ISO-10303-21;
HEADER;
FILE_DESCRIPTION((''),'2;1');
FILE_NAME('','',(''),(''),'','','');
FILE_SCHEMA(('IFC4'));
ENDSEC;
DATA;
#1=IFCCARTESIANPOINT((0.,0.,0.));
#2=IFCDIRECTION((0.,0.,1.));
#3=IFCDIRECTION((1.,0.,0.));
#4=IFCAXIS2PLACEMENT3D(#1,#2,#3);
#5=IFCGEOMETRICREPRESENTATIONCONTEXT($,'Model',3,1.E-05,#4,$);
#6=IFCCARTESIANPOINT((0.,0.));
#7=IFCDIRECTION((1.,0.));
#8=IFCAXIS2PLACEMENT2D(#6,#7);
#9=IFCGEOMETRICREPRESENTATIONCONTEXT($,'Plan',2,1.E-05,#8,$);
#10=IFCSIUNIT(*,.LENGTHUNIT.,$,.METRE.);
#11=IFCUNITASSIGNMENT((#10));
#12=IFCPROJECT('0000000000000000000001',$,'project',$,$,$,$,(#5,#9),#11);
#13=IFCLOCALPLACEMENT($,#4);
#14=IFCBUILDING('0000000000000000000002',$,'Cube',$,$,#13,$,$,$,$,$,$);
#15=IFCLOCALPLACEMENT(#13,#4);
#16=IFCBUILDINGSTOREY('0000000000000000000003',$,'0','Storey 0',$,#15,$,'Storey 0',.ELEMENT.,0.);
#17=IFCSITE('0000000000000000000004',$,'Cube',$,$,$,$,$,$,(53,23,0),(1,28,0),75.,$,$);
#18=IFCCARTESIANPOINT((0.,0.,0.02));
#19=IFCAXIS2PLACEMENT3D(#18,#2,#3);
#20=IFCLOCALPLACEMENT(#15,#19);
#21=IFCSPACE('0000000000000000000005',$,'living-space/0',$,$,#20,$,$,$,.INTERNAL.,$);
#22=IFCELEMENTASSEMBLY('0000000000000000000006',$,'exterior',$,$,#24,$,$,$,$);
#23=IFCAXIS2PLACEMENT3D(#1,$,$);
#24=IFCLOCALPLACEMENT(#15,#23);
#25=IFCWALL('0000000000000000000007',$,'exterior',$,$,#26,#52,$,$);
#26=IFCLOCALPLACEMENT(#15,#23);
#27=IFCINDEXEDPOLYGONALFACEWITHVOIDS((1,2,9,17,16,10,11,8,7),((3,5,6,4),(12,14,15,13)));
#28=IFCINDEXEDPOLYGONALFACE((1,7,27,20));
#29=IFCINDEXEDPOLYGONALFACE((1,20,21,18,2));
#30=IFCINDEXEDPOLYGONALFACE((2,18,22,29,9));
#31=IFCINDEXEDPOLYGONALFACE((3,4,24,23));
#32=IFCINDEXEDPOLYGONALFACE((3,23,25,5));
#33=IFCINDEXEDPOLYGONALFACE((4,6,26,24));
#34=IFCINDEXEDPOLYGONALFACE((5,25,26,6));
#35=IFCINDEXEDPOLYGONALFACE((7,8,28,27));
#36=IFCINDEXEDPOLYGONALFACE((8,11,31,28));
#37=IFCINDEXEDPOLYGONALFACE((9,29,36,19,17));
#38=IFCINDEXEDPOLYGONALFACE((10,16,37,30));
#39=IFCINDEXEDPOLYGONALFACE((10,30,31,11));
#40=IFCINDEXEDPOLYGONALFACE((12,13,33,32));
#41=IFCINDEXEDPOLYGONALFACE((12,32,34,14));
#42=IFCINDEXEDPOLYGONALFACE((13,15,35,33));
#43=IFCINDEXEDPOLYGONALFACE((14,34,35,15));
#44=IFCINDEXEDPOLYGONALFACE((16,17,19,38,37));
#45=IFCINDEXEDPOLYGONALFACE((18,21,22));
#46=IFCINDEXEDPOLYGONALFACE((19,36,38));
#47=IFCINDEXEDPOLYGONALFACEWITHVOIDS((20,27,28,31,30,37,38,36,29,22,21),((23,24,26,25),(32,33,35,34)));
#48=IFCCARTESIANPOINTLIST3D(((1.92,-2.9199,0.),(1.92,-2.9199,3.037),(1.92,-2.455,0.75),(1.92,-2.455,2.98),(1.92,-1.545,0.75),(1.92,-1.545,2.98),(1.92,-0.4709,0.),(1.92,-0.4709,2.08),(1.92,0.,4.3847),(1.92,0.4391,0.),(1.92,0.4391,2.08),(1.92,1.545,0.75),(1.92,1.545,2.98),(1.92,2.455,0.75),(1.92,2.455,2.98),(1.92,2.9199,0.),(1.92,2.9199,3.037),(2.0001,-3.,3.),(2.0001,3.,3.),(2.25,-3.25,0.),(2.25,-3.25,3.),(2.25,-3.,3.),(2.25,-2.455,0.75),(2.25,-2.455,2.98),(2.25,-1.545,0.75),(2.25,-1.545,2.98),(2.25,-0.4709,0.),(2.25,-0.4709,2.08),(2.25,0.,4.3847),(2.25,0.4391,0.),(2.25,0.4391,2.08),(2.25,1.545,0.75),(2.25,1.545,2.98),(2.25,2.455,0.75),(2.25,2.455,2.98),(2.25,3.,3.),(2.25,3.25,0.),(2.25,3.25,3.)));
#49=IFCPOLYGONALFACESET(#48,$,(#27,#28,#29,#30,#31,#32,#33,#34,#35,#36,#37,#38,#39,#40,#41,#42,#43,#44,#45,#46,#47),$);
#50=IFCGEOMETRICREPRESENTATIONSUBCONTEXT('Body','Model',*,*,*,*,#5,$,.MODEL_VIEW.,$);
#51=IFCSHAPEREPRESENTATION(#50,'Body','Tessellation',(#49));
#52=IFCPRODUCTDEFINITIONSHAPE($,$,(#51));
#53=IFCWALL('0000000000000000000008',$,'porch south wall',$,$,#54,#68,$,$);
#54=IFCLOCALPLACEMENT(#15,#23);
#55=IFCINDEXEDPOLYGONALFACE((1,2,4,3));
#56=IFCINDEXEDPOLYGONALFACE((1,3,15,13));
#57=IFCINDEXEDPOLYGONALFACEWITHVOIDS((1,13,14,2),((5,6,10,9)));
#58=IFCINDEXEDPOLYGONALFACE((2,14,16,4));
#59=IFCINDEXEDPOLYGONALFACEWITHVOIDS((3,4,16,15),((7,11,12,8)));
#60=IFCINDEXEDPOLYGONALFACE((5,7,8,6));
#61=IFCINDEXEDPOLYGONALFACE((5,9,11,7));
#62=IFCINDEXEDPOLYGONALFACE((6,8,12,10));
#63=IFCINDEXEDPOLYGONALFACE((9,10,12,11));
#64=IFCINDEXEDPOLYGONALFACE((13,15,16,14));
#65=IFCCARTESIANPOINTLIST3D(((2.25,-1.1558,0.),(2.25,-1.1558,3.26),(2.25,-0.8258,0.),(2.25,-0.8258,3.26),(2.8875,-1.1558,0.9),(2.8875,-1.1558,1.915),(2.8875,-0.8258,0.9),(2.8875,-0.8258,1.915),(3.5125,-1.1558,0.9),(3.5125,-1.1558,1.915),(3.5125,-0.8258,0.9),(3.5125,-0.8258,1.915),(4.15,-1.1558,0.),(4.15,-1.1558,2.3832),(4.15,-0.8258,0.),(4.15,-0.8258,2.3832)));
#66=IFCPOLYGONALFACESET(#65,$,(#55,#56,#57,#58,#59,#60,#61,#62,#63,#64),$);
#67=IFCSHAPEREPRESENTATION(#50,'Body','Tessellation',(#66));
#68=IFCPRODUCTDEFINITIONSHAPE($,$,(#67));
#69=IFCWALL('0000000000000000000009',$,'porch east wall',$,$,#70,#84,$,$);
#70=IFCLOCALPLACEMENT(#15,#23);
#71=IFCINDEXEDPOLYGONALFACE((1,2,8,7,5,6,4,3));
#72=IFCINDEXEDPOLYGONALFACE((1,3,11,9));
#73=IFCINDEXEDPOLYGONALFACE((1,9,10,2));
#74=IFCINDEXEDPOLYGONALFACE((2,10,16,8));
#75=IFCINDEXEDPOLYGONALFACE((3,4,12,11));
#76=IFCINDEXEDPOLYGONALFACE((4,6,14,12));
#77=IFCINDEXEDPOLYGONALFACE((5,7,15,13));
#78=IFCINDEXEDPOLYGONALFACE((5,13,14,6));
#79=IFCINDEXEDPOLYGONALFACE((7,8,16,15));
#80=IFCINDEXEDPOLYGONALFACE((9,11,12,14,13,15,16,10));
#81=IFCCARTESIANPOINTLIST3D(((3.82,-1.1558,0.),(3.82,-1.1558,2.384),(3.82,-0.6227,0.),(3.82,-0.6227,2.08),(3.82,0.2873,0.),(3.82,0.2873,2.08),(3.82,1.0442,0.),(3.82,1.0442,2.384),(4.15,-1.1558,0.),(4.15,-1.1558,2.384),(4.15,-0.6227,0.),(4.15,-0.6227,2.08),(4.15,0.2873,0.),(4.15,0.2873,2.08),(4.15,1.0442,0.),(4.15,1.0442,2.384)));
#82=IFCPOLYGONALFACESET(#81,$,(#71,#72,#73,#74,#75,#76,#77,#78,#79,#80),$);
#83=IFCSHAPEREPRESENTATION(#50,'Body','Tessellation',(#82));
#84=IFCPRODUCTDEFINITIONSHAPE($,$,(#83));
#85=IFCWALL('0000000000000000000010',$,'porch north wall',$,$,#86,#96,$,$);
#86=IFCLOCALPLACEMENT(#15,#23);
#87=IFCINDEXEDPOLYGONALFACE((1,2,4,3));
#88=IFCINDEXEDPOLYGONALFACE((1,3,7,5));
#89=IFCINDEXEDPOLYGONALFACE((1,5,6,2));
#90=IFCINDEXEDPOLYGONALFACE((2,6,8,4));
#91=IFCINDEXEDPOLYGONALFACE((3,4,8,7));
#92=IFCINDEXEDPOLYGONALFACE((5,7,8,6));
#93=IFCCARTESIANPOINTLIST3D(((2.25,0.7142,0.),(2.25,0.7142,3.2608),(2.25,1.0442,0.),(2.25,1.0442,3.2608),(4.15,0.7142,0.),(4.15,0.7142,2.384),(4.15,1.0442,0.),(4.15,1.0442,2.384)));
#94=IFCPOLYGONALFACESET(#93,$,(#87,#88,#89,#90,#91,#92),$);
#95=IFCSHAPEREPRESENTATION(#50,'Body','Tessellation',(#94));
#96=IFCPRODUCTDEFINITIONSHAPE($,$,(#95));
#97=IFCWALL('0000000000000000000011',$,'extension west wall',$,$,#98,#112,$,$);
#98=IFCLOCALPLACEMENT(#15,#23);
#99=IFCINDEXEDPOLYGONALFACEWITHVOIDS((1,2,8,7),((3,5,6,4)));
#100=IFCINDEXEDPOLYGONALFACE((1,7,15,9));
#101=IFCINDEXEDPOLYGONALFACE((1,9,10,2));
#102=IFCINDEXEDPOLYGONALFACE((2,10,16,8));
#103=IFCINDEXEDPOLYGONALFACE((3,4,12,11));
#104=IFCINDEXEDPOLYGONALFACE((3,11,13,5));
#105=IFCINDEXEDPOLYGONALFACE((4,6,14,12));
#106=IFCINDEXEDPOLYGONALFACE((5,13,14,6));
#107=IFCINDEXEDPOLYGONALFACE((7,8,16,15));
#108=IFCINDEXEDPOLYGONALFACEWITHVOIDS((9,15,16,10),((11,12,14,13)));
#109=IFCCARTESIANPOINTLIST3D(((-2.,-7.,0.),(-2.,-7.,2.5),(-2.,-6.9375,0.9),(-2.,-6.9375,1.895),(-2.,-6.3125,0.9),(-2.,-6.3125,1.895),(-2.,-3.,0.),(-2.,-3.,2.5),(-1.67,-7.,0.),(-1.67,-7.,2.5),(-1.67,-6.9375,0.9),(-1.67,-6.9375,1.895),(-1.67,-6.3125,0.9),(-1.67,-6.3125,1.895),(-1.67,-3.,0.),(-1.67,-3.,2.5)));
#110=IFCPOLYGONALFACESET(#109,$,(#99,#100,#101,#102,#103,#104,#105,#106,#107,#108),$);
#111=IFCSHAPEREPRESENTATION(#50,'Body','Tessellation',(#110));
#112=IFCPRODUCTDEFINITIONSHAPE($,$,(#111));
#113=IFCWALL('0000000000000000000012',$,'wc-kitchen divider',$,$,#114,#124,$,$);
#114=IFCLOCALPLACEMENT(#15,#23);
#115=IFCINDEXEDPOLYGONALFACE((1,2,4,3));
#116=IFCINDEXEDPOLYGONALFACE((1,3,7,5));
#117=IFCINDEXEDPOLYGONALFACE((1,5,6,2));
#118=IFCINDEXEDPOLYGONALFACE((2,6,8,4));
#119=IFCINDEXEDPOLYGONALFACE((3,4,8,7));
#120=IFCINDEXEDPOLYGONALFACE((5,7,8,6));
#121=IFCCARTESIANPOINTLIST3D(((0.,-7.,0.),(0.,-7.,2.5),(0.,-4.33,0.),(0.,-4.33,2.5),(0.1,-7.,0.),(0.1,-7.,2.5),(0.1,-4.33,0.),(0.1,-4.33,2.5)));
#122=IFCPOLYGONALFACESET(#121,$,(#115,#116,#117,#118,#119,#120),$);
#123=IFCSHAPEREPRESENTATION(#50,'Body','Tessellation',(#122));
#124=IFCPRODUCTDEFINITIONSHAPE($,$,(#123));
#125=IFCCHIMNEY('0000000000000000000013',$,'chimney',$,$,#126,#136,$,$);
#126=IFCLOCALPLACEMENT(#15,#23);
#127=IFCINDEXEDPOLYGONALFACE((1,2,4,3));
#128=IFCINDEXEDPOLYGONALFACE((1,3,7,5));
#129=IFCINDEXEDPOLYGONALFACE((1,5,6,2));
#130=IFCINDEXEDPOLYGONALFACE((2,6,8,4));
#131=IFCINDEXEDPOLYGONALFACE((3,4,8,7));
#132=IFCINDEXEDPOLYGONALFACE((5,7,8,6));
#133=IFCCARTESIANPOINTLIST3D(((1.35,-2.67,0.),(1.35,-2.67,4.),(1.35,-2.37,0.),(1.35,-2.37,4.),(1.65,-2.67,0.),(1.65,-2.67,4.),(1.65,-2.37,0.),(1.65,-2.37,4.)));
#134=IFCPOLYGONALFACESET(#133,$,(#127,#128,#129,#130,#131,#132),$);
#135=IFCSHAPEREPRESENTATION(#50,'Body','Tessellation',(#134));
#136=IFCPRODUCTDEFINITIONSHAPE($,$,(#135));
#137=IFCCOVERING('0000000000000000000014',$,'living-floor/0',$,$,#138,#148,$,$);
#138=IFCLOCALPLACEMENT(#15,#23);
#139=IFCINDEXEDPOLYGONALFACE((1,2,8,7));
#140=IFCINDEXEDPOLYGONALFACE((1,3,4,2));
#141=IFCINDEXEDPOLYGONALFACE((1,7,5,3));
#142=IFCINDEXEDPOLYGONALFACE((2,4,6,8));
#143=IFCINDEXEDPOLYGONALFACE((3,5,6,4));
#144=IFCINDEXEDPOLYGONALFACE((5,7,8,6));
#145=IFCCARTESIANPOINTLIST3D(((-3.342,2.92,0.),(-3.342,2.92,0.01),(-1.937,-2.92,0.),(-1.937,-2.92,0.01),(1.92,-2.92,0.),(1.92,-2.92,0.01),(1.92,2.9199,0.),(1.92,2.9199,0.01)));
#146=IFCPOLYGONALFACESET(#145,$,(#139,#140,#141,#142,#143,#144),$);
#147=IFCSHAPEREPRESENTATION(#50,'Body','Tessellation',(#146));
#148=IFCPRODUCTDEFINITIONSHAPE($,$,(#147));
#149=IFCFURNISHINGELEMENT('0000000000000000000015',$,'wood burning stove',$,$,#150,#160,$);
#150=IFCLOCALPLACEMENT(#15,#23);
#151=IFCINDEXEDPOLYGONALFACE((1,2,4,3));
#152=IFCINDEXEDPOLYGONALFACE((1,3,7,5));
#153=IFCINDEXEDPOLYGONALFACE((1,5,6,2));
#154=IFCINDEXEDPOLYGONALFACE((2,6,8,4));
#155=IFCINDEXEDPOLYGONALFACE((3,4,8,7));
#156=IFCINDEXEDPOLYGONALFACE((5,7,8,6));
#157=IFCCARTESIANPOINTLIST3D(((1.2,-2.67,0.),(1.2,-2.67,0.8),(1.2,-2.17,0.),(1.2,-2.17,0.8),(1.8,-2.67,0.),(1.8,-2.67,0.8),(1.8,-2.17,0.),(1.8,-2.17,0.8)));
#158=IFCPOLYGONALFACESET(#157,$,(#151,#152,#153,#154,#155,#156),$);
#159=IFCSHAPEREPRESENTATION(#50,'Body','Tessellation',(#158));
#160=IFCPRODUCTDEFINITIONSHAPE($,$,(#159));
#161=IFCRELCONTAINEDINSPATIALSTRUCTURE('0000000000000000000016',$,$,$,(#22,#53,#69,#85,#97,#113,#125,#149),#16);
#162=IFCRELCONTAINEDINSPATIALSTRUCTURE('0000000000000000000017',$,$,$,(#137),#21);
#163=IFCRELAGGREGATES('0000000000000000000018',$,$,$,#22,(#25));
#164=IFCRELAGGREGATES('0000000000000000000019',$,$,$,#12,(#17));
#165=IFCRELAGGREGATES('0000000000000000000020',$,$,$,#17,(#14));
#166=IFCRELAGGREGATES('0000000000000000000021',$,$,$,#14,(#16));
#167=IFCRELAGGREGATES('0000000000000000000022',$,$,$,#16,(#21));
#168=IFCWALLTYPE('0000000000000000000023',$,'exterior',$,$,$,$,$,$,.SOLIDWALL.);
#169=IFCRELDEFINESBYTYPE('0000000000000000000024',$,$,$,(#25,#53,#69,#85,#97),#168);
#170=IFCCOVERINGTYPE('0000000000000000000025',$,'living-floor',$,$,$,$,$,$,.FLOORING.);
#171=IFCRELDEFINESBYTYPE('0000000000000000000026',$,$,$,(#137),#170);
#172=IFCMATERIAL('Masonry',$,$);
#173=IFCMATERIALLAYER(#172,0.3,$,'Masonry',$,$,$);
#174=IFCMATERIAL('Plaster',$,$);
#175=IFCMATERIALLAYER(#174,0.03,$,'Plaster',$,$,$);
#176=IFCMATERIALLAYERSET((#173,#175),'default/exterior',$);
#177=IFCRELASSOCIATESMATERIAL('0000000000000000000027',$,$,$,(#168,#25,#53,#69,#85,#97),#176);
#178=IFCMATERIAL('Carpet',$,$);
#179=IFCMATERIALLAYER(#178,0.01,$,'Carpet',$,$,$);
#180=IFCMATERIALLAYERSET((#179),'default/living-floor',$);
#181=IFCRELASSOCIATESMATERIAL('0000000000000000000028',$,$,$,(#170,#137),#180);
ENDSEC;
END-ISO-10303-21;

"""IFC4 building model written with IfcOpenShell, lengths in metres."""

from ifc_helpers import new_model, si_unit, frame, origin, origin_with_axes, origin_2d_with_axis, place, context, subcontext, project, spatial, polyline, line, indexed_curve, outline, extrude, clip, halfspace, bounded_halfspace, source, transform, mapped, material, layer, layer_set, layer_usage, type_object, element, aggregate, save


model = new_model("IFC4")

# Units and contexts
model_context = context("Model", 3, precision=1e-05, world=origin_with_axes())
plan_context = context("Plan", 2, precision=1e-05, world=origin_2d_with_axis())
body_context = subcontext(model_context, "Body", "Model", "MODEL_VIEW")
ifc_project = project(units=[si_unit("LENGTHUNIT", "METRE")], contexts=[model_context, plan_context])

# Site, building, storey
site = spatial("IfcSite", under=ifc_project, Name="Cube", RefLatitude=(53, 23, 0), RefLongitude=(1, 28, 0), RefElevation=75.0)
building_placement = place(None, origin_with_axes())
building = spatial("IfcBuilding", under=site, at=building_placement, Name="Cube")
storey_placement = place(building_placement, origin_with_axes())
storey = spatial("IfcBuildingStorey", under=building, at=storey_placement, Name="0", Description="Storey 0", LongName="Storey 0", CompositionType="ELEMENT", Elevation=0.0)

# Element assembly, wall, openings
ifc_material_1 = material(Name="Masonry")
ifc_layer_1 = layer(ifc_material_1, 0.3, Name="Masonry")
ifc_material_2 = material(Name="Plaster")
ifc_layer_2 = layer(ifc_material_2, 0.03, Name="Plaster")
ifc_layer_set_1 = layer_set([ifc_layer_1, ifc_layer_2], Name="default/exterior")
wall_type = type_object("IfcWallType", Name="exterior", PredefinedType="SOLIDWALL", material=ifc_layer_set_1)
assembly_1_placement = place(storey_placement, frame((2.0, -3.0, 0.0), z_axis=(0.0, 0.0, 1.0), x_axis=(0.0, 1.0, 0.0)))
assembly_1 = element("IfcElementAssembly", 1, at=assembly_1_placement, inside=storey, Name="exterior")
ifc_layer_usage_1 = layer_usage(ifc_layer_set_1, "AXIS2", "POSITIVE", -0.25)
wall_1_placement = place(assembly_1_placement, origin_with_axes())
wall_1 = element("IfcWall", 2, at=wall_1_placement, type_object=wall_type, material=ifc_layer_usage_1, Name="exterior", context=body_context, shape_type="Clipping", body=[
    clip(clip(clip(clip(extrude(outline(polyline([(0.0801, 0.08), (-0.25, -0.25), (6.25, -0.25), (5.9199, 0.08), (0.0801, 0.08)])), origin(), (0.0, 0.0, 1.0), 4.385), bounded_halfspace(frame((6.0, 0.0, 3.0), z_axis=(0.419069, 0.0, 0.907954), x_axis=(0.0, -1.0, 0.0)), False, origin(), polyline([(6.0, -1.0), (3.0, -1.0), (3.0, 1.0), (6.0, 1.0), (6.0, -1.0)]))), bounded_halfspace(frame((6.0, 0.0, 3.0), z_axis=(0.0, 0.0, 1.0), x_axis=(0.0, 1.0, 0.0)), False, origin(), polyline([(6.0, 1.0), (7.0, 1.0), (7.0, -1.0), (6.0, -1.0), (6.0, 1.0)]))), bounded_halfspace(frame((3.0, 0.0, 4.3847), z_axis=(-0.419069, 0.0, 0.907954), x_axis=(0.0, -1.0, 0.0)), False, origin(), polyline([(3.0, -1.0), (0.0, -1.0), (0.0, 1.0), (3.0, 1.0), (3.0, -1.0)]))), bounded_halfspace(frame((0.0, 0.0, 3.0), z_axis=(0.0, 0.0, 1.0), x_axis=(0.0, -1.0, 0.0)), False, origin(), polyline([(0.0, -1.0), (-1.0, -1.0), (-1.0, 1.0), (0.0, 1.0), (0.0, -1.0)]))),
])
opening_1_placement = place(wall_1_placement, frame((0.545, -0.25, 0.75), z_axis=(0.0, 0.0, 1.0), x_axis=(1.0, 0.0, 0.0)))
element("IfcOpeningElement", 3, at=opening_1_placement, cuts=wall_1, PredefinedType="OPENING", context=body_context, shape_type="SweptSolid", body=[
    extrude(outline(polyline([(0.0, -0.02), (0.91, -0.02), (0.91, 0.35), (0.0, 0.35), (0.0, -0.02)])), origin(), (0.0, 0.0, 1.0), 2.23),
])
opening_2_placement = place(wall_1_placement, frame((4.545, -0.25, 0.75), z_axis=(0.0, 0.0, 1.0), x_axis=(1.0, 0.0, 0.0)))
element("IfcOpeningElement", 4, at=opening_2_placement, cuts=wall_1, PredefinedType="OPENING", context=body_context, shape_type="SweptSolid", body=[
    extrude(outline(polyline([(0.0, -0.02), (0.91, -0.02), (0.91, 0.35), (0.0, 0.35), (0.0, -0.02)])), origin(), (0.0, 0.0, 1.0), 2.23),
])
shared_shape_1 = source(origin_with_axes(), body_context, "Body", "SweptSolid", [
    extrude(outline(indexed_curve([(0.0, 0.0), (0.91, 0.0), (0.91, 2.08), (0.0, 2.08)], segments=[line(1, 2, 3, 4, 1)])), frame((0.0, -0.6, 0.0), z_axis=(0.0, -1.0, 0.0), x_axis=(1.0, 0.0, 0.0)), (0.0, 0.0, -1.0), 1.2),
])
opening_3_placement = place(wall_1_placement, frame((2.5291, -0.25, 0.0), z_axis=(0.0, 0.0, 1.0), x_axis=(1.0, 0.0, 0.0)))
element("IfcOpeningElement", 5, at=opening_3_placement, cuts=wall_1, PredefinedType="OPENING", context=body_context, shape_type="MappedRepresentation", body=[
    mapped(shared_shape_1, transform((0.0, 0.0, 0.0), x_axis=(1.0, 0.0, 0.0), y_axis=(0.0, 1.0, 0.0), z_axis=(0.0, 0.0, 1.0), scale=1.0)),
])
aggregate(assembly_1, [wall_1])

# Walls, openings
ifc_layer_usage_2 = layer_usage(ifc_layer_set_1, "AXIS2", "POSITIVE", 0.0)
wall_2_placement = place(storey_placement, frame((2.25, -1.1558, 0.0), z_axis=(0.0, 0.0, 1.0), x_axis=(1.0, 0.0, 0.0)))
wall_2 = element("IfcWall", 6, at=wall_2_placement, inside=storey, type_object=wall_type, material=ifc_layer_usage_2, Name="porch south wall", context=body_context, shape_type="Clipping", body=[
    clip(extrude(outline(indexed_curve([(0.0, 0.0), (0.0, 0.33), (1.9, 0.33), (1.9, 0.0), (0.0, 0.0)], self_intersect=False)), origin_with_axes(), (0.0, 0.0, 1.0), 3.5), halfspace(frame((0.0, 0.0, 3.26), z_axis=(0.419, 0.0, 0.908), x_axis=(0.0, 1.0, 0.0)), False)),
])
opening_4_placement = place(wall_2_placement, frame((0.6375, -0.0002, 0.9), z_axis=(0.0, 0.0, 1.0), x_axis=(1.0, 0.0, 0.0)))
element("IfcOpeningElement", 7, at=opening_4_placement, cuts=wall_2, context=body_context, shape_type="SweptSolid", body=[
    extrude(outline(indexed_curve([(0.0, 0.0), (0.0, 0.5), (0.625, 0.5), (0.625, 0.0), (0.0, 0.0)], self_intersect=False)), origin_with_axes(), (0.0, 0.0, 1.0), 1.015),
])
ifc_layer_usage_3 = layer_usage(ifc_layer_set_1, "AXIS2", "POSITIVE", 0.0)
wall_3_placement = place(storey_placement, frame((4.15, -1.1558, 0.0), z_axis=(0.0, 0.0, 1.0), x_axis=(0.0, 1.0, 0.0)))
wall_3 = element("IfcWall", 8, at=wall_3_placement, inside=storey, type_object=wall_type, material=ifc_layer_usage_3, Name="porch east wall", context=body_context, shape_type="SweptSolid", body=[
    extrude(outline(indexed_curve([(0.0, 0.0), (0.0, 0.33), (2.2, 0.33), (2.2, 0.0), (0.0, 0.0)], self_intersect=False)), origin_with_axes(), (0.0, 0.0, 1.0), 2.384),
])
shared_shape_2 = source(origin_with_axes(), body_context, "Body", "SweptSolid", [
    extrude(outline(indexed_curve([(0.0, 0.0), (0.91, 0.0), (0.91, 2.08), (0.0, 2.08)], segments=[line(1, 2, 3, 4, 1)])), frame((0.0, -0.6, 0.0), z_axis=(0.0, -1.0, 0.0), x_axis=(1.0, 0.0, 0.0)), (0.0, 0.0, -1.0), 1.2),
])
opening_5_placement = place(wall_3_placement, frame((0.5331, 0.0, 0.0), z_axis=(0.0, 0.0, 1.0), x_axis=(1.0, 0.0, 0.0)))
element("IfcOpeningElement", 9, at=opening_5_placement, cuts=wall_3, PredefinedType="OPENING", context=body_context, shape_type="MappedRepresentation", body=[
    mapped(shared_shape_2, transform((0.0, 0.0, 0.0), x_axis=(1.0, 0.0, 0.0), y_axis=(0.0, 1.0, 0.0), z_axis=(0.0, 0.0, 1.0), scale=1.0)),
])

# Wall
ifc_layer_usage_4 = layer_usage(ifc_layer_set_1, "AXIS2", "POSITIVE", 0.0)
wall_4_placement = place(storey_placement, frame((4.15, 1.0442, 0.0), z_axis=(0.0, 0.0, 1.0), x_axis=(-1.0, 0.0, 0.0)))
element("IfcWall", 10, at=wall_4_placement, inside=storey, type_object=wall_type, material=ifc_layer_usage_4, Name="porch north wall", context=body_context, shape_type="Clipping", body=[
    clip(extrude(outline(indexed_curve([(0.0, 0.0), (0.0, 0.33), (1.9, 0.33), (1.9, 0.0), (0.0, 0.0)], self_intersect=False)), origin_with_axes(), (0.0, 0.0, 1.0), 3.5), halfspace(frame((0.0, 0.0, 2.384), z_axis=(-0.419, 0.0, 0.908), x_axis=(0.0, -1.0, 0.0)), False)),
])

# Wall, opening
ifc_layer_usage_5 = layer_usage(ifc_layer_set_1, "AXIS2", "POSITIVE", 0.0)
wall_5_placement = place(storey_placement, frame((-2.0, -3.0, 0.0), z_axis=(0.0, 0.0, 1.0), x_axis=(0.0, -1.0, 0.0)))
wall_5 = element("IfcWall", 11, at=wall_5_placement, inside=storey, type_object=wall_type, material=ifc_layer_usage_5, Name="extension west wall", context=body_context, shape_type="SweptSolid", body=[
    extrude(outline(indexed_curve([(0.0, 0.0), (0.0, 0.33), (4.0, 0.33), (4.0, 0.0), (0.0, 0.0)], self_intersect=False)), origin_with_axes(), (0.0, 0.0, 1.0), 2.5),
])
opening_6_placement = place(wall_5_placement, frame((3.3125, 0.0, 0.9), z_axis=(0.0, 0.0, 1.0), x_axis=(1.0, 0.0, 0.0)))
element("IfcOpeningElement", 12, at=opening_6_placement, cuts=wall_5, PredefinedType="OPENING", context=body_context, shape_type="SweptSolid", body=[
    extrude(outline(indexed_curve([(0.0, 0.0), (0.0, 0.5), (0.625, 0.5), (0.625, 0.0), (0.0, 0.0)], self_intersect=False)), origin_with_axes(), (0.0, 0.0, 1.0), 0.995),
])

# Wall
wall_6_placement = place(storey_placement, frame((0.0, -4.33, 0.0), z_axis=(0.0, 0.0, 1.0), x_axis=(0.0, -1.0, 0.0)))
element("IfcWall", 13, at=wall_6_placement, inside=storey, Name="wc-kitchen divider", context=body_context, shape_type="SweptSolid", body=[
    extrude(outline(indexed_curve([(0.0, 0.0), (0.0, 0.1), (2.67, 0.1), (2.67, 0.0), (0.0, 0.0)], self_intersect=False)), origin_with_axes(), (0.0, 0.0, 1.0), 2.5),
])

# Chimney
chimney_placement = place(storey_placement, frame((1.35, -2.67, 0.0), z_axis=(0.0, 0.0, 1.0), x_axis=(1.0, 0.0, 0.0)))
element("IfcChimney", 14, at=chimney_placement, inside=storey, Name="chimney", context=body_context, shape_type="SweptSolid", body=[
    extrude(outline(indexed_curve([(0.0, 0.0), (0.3, 0.0), (0.3, 0.3), (0.0, 0.3)])), None, (0.0, 0.0, 1.0), 4.0),
])

# Shared definitions
space_placement = place(storey_placement, frame((0.0, 0.0, 0.02), z_axis=(0.0, 0.0, 1.0), x_axis=(1.0, 0.0, 0.0)))
space = spatial("IfcSpace", under=storey, at=space_placement, Name="living-space/0", PredefinedType="INTERNAL")

# Covering
ifc_material_3 = material(Name="Carpet")
ifc_layer_3 = layer(ifc_material_3, 0.01, Name="Carpet")
ifc_layer_set_2 = layer_set([ifc_layer_3], Name="default/living-floor")
ifc_layer_usage_6 = layer_usage(ifc_layer_set_2, "AXIS3", "POSITIVE", 0.0)
covering_type = type_object("IfcCoveringType", Name="living-floor", PredefinedType="FLOORING", material=ifc_layer_set_2)
covering_placement = place(space_placement, frame((0.0, 0.0, -0.02), z_axis=(0.0, 0.0, 1.0), x_axis=(1.0, 0.0, 0.0)))
element("IfcCovering", 15, at=covering_placement, inside=space, type_object=covering_type, material=ifc_layer_usage_6, Name="living-floor/0", context=body_context, shape_type="SweptSolid", body=[
    extrude(outline(polyline([(1.92, 2.9199), (-3.342, 2.92), (-1.937, -2.92), (1.92, -2.92), (1.92, 2.9199)])), origin_with_axes(), (0.0, 0.0, 1.0), 0.01),
])

# Furnishing element
furnishing_1_placement = place(storey_placement, frame((1.2, -2.67, 0.0), z_axis=(0.0, 0.0, 1.0), x_axis=(1.0, 0.0, 0.0)))
element("IfcFurnishingElement", 16, at=furnishing_1_placement, inside=storey, Name="wood burning stove", context=body_context, shape_type="SweptSolid", body=[
    extrude(outline(indexed_curve([(0.0, 0.0), (0.6, 0.0), (0.6, 0.5), (0.0, 0.5)])), None, (0.0, 0.0, 1.0), 0.8),
])

save(model, "model.ifc")
